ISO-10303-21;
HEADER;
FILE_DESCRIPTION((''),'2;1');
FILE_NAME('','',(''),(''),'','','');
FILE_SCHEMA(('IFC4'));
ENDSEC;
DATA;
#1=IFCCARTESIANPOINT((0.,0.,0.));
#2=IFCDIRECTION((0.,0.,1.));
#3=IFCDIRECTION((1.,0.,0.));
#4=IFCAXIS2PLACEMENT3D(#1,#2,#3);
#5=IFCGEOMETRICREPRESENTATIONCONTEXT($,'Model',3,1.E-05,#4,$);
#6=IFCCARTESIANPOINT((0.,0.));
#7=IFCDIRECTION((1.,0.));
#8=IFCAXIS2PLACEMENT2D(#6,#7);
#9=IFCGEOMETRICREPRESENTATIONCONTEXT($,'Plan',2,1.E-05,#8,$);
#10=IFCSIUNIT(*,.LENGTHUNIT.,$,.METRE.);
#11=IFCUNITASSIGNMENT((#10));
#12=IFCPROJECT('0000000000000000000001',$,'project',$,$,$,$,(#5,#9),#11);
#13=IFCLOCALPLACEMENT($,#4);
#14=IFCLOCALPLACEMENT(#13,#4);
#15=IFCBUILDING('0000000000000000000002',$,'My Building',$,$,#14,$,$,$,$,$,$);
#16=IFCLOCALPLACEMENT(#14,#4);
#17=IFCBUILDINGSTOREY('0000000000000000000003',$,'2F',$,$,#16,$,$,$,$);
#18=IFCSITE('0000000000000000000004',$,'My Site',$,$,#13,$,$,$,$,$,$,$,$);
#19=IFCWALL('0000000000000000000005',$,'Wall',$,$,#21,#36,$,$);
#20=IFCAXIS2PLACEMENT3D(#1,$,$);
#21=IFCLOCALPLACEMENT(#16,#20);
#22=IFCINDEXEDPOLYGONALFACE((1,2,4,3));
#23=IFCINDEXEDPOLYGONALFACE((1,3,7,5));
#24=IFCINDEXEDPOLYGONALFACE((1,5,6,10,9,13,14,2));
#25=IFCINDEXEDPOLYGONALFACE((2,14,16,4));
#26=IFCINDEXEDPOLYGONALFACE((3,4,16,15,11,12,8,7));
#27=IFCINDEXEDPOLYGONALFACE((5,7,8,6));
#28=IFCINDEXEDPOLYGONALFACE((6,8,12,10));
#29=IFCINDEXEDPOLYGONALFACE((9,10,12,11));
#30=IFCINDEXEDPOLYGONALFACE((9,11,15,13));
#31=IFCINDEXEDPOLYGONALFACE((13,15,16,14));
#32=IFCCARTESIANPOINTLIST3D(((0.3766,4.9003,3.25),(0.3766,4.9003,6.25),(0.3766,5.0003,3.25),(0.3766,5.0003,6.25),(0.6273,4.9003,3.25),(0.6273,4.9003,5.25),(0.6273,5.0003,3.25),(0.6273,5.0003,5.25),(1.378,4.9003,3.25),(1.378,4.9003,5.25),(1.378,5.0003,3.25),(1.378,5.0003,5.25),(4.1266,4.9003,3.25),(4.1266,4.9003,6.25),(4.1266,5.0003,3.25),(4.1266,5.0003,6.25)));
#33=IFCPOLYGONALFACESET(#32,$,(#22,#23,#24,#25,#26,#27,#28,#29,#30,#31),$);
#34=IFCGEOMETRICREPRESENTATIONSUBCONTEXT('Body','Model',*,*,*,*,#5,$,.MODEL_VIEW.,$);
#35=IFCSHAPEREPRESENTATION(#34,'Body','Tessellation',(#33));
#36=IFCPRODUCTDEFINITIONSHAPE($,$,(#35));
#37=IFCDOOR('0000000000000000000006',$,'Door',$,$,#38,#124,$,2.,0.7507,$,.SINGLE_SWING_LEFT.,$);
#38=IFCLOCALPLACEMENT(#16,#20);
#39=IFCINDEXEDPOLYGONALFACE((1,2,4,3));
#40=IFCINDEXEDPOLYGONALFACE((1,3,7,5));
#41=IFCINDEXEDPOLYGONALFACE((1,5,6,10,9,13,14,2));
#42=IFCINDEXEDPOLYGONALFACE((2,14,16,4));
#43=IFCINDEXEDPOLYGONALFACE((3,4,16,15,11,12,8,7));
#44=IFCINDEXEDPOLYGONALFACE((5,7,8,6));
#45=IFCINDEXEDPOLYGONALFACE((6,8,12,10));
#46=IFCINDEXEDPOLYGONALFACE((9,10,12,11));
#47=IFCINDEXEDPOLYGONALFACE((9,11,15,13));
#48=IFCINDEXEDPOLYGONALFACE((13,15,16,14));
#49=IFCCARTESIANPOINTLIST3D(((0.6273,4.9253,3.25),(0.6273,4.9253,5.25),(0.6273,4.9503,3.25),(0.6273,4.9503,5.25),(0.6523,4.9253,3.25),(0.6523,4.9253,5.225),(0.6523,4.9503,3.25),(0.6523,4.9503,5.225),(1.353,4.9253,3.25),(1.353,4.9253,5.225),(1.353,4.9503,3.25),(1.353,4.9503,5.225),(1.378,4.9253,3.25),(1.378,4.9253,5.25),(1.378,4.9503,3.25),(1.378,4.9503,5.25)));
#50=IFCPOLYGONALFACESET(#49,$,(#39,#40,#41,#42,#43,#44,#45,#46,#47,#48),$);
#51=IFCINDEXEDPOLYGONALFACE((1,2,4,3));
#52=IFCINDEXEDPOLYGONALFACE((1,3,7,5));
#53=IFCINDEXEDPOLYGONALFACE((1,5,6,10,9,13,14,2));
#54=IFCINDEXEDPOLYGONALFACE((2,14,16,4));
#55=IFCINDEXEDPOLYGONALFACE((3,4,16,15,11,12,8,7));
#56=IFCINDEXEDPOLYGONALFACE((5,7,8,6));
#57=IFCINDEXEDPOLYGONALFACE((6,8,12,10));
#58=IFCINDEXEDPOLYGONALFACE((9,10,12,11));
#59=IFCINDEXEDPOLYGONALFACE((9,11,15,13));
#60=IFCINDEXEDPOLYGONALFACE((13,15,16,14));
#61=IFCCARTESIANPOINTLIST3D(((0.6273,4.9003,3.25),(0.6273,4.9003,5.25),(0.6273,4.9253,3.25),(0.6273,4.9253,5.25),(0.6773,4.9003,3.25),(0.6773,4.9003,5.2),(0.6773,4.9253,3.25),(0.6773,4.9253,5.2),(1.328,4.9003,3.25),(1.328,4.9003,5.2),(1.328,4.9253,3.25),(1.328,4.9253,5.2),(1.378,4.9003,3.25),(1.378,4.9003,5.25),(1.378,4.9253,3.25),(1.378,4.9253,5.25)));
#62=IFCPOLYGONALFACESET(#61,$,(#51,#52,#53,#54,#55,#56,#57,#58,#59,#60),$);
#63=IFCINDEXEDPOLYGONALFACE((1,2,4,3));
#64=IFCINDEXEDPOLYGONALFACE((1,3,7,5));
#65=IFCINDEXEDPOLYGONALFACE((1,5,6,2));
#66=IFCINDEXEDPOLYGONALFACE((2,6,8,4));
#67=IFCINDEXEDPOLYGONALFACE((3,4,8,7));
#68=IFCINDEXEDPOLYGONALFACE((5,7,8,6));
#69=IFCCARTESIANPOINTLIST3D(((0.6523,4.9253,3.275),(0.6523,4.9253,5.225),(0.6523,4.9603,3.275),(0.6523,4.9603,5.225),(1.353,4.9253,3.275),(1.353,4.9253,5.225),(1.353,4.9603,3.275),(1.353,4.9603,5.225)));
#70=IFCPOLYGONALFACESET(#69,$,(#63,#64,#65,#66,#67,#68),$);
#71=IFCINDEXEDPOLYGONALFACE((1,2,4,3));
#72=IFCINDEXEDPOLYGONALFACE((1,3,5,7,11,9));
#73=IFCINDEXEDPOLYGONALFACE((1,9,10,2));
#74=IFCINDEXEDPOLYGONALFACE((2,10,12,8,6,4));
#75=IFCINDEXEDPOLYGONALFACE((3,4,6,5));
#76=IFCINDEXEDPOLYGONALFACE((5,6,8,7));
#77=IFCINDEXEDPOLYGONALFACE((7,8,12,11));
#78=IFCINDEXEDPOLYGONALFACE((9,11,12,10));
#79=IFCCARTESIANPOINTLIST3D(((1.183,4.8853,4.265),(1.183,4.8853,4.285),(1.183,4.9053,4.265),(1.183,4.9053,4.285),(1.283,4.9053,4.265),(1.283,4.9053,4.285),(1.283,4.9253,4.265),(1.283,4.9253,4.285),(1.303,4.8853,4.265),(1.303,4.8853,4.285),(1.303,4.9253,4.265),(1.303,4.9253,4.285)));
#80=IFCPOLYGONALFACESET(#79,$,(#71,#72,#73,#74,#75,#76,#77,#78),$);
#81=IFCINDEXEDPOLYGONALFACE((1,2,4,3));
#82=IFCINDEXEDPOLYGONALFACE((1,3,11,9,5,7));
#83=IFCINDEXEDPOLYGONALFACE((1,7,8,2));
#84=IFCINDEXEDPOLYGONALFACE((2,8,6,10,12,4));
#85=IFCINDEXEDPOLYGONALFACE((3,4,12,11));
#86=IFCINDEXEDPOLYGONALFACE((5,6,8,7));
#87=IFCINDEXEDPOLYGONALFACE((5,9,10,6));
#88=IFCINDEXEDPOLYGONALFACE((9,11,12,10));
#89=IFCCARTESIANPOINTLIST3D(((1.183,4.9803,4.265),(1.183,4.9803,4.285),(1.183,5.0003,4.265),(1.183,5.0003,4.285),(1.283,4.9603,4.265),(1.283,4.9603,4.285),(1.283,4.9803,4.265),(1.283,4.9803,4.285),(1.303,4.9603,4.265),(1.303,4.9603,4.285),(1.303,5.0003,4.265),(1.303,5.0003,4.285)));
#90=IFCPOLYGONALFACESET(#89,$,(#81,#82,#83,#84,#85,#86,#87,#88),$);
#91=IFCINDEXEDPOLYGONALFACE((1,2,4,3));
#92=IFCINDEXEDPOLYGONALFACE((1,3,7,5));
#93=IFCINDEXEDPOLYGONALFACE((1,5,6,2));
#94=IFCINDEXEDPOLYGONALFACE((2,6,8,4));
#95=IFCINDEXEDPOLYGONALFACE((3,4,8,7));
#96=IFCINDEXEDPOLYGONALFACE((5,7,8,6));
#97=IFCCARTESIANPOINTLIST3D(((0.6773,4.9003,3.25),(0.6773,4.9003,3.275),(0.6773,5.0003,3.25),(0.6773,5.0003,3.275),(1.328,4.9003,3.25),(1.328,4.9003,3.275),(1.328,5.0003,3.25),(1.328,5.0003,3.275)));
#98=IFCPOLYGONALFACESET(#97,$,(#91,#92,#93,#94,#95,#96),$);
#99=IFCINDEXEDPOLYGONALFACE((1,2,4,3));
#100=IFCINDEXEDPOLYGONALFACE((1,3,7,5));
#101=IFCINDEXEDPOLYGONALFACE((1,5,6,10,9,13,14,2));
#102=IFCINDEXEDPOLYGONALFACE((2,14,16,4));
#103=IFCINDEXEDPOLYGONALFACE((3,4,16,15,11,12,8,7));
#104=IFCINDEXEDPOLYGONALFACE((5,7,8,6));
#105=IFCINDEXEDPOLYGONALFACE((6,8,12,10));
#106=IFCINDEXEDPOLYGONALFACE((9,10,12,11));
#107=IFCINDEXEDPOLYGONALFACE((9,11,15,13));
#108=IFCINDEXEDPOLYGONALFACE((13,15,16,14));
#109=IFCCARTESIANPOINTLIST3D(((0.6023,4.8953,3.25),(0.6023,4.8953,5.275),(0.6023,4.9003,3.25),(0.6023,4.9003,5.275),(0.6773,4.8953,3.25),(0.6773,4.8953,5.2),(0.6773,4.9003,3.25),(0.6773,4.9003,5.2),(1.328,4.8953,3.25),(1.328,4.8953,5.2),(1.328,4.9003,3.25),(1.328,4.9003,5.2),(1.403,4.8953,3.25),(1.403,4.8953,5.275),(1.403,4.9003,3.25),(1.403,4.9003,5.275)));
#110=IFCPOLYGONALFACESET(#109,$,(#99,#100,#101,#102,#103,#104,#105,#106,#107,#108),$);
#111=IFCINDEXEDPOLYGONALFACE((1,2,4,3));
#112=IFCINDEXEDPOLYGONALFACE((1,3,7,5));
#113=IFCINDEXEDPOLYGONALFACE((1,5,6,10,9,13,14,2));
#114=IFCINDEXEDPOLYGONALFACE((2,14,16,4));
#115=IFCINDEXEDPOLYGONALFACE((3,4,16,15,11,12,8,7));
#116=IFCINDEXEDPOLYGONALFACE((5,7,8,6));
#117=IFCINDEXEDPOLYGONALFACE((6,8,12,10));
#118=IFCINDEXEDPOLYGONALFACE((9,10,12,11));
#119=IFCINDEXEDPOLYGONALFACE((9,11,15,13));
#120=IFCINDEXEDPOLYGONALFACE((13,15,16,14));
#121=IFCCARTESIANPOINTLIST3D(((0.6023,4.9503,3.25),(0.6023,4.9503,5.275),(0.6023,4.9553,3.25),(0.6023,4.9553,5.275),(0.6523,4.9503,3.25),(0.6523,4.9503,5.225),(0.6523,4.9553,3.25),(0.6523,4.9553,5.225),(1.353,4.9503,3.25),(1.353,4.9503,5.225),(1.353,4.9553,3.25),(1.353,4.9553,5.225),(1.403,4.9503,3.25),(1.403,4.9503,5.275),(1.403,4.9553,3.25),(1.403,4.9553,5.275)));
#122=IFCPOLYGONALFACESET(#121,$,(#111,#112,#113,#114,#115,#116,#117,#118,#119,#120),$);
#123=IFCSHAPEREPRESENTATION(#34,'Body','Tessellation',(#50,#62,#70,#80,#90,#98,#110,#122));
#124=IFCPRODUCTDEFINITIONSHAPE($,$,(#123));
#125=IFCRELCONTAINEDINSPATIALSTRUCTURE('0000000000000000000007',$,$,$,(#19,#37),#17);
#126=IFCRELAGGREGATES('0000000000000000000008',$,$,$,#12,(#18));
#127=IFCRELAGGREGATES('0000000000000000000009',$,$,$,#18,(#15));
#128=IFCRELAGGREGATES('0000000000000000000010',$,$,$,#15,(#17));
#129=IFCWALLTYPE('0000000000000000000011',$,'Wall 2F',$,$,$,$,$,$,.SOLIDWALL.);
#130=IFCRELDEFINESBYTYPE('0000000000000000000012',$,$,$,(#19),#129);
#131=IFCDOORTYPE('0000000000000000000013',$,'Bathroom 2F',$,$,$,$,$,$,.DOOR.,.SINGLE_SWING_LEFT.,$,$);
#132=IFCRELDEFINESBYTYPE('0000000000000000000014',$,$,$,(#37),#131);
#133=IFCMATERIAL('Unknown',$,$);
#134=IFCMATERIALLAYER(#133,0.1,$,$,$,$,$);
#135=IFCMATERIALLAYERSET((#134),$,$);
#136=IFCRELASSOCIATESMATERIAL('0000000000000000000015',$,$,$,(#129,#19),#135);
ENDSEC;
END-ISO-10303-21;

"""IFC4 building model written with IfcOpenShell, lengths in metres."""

from ifc_helpers import new_model, entity, si_unit, frame, origin_with_axes, origin_2d_with_axis, place, context, subcontext, project, spatial, line, indexed_curve, outline, extrude, shape, source, transform, mapped, material, layer, layer_set, layer_usage, type_object, type_shapes, element, fill, save


model = new_model("IFC4")

# Units and contexts
model_context = context("Model", 3, precision=1e-05, world=origin_with_axes())
plan_context = context("Plan", 2, precision=1e-05, world=origin_2d_with_axis())
body_context_1 = subcontext(model_context, "Body", "Model", "MODEL_VIEW")
body_context_2 = subcontext(plan_context, "Body", "Plan", "PLAN_VIEW")
ifc_project = project(units=[si_unit("LENGTHUNIT", "METRE")], contexts=[model_context, plan_context])

# Site, building, storey
site_placement = place(None, origin_with_axes())
site = spatial("IfcSite", under=ifc_project, at=site_placement, Name="My Site")
building_placement = place(site_placement, origin_with_axes())
building = spatial("IfcBuilding", under=site, at=building_placement, Name="My Building")
storey_placement = place(building_placement, origin_with_axes())
storey = spatial("IfcBuildingStorey", under=building, at=storey_placement, Name="2F")

# Shared definitions
ifc_material = material(Name="Unknown")

# Shared definitions
ifc_layer = layer(ifc_material, 0.1)
ifc_layer_set = layer_set([ifc_layer])
wall_type = type_object("IfcWallType", Name="Wall 2F", PredefinedType="SOLIDWALL", material=ifc_layer_set)

# Wall, opening, door
ifc_layer_usage_1 = layer_usage(ifc_layer_set, "AXIS2", "POSITIVE", 0.0)
wall_1_placement = place(storey_placement, frame((4.2266, 5.0003, 3.25), z_axis=(0.0, 0.0, 1.0), x_axis=(-1.0, 0.0, 0.0)))
wall_1 = element("IfcWall", 1, at=wall_1_placement, inside=storey, type_object=wall_type, material=ifc_layer_usage_1, Name="Wall", context=body_context_1, shape_type="SweptSolid", body=[
    extrude(outline(indexed_curve([(0.1, 0.0), (0.1, 0.1), (3.85, 0.1), (3.85, 0.0)], segments=[line(1, 2, 3, 4, 1)])), origin_with_axes(), (0.0, 0.0, 1.0), 3.0),
])
shared_shape_1 = source(origin_with_axes(), body_context_1, "Body", "SweptSolid", [
    extrude(outline(indexed_curve([(0.0, 0.0), (0.7507, 0.0), (0.7507, 2.0), (0.0, 2.0)], segments=[line(1, 2, 3, 4, 1)])), frame((0.0, -0.6, 0.0), z_axis=(0.0, -1.0, 0.0), x_axis=(1.0, 0.0, 0.0)), (0.0, 0.0, -1.0), 1.2),
])
opening_1_placement = place(wall_1_placement, frame((3.5993, 0.1, 0.0), z_axis=(0.0, 0.0, 1.0), x_axis=(-1.0, 0.000001, 0.0)))
opening_1 = element("IfcOpeningElement", 2, at=opening_1_placement, cuts=wall_1, PredefinedType="OPENING", context=body_context_1, shape_type="MappedRepresentation", body=[
    mapped(shared_shape_1, transform((0.0, 0.0, 0.0), x_axis=(1.0, 0.0, 0.0), y_axis=(0.0, 1.0, 0.0), z_axis=(0.0, 0.0, 1.0), scale=1.0)),
])
door_type_1 = type_object("IfcDoorType", Name="Bathroom 2F", OperationType="SINGLE_SWING_LEFT", PredefinedType="DOOR")
shared_shape_2 = source(origin_with_axes(), body_context_1, "Body", "SweptSolid", [
    extrude(outline(indexed_curve([(0.0, 0.0), (0.0, 2.0), (0.7507, 2.0), (0.7507, 0.0), (0.7257, 0.0), (0.7257, 1.975), (0.025, 1.975), (0.025, 0.0)], segments=[line(1, 2, 3, 4, 5, 6, 7, 8, 1)])), frame((0.0, 0.025, 0.0), z_axis=(0.0, -1.0, 0.0), x_axis=(1.0, 0.0, 0.0)), (0.0, 0.0, -1.0), 0.025),
    extrude(outline(indexed_curve([(0.0, 0.0), (0.0, 2.0), (0.7507, 2.0), (0.7507, 0.0), (0.7007, 0.0), (0.7007, 1.95), (0.05, 1.95), (0.05, 0.0)], segments=[line(1, 2, 3, 4, 5, 6, 7, 8, 1)])), frame((0.0, 0.0, 0.0), z_axis=(0.0, -1.0, 0.0), x_axis=(1.0, 0.0, 0.0)), (0.0, 0.0, -1.0), 0.025),
    extrude(outline(indexed_curve([(0.0, 0.0), (0.7007, 0.0), (0.7007, 0.035), (0.0, 0.035)], segments=[line(1, 2, 3, 4, 1)])), frame((0.025, 0.025, 0.025), z_axis=(0.0, 0.0, 1.0), x_axis=(1.0, 0.0, 0.0)), (0.0, 0.0, 1.0), 1.95),
    extrude(outline(indexed_curve([(0.0, 0.0), (0.0, -0.04), (-0.12, -0.04), (-0.12, -0.02), (-0.02, -0.02), (-0.02, 0.0)], segments=[line(1, 2, 3, 4, 5, 6, 1)])), frame((0.6757, 0.025, 1.015), z_axis=(0.0, 0.0, 1.0), x_axis=(1.0, 0.0, 0.0)), (0.0, 0.0, 1.0), 0.02),
    extrude(outline(indexed_curve([(0.0, 0.0), (0.0, 0.04), (-0.12, 0.04), (-0.12, 0.02), (-0.02, 0.02), (-0.02, 0.0)], segments=[line(1, 2, 3, 4, 5, 6, 1)])), frame((0.6757, 0.06, 1.015), z_axis=(0.0, 0.0, 1.0), x_axis=(1.0, 0.0, 0.0)), (0.0, 0.0, 1.0), 0.02),
    extrude(outline(indexed_curve([(0.0, 0.0), (0.6507, 0.0), (0.6507, 0.1), (0.0, 0.1)], segments=[line(1, 2, 3, 4, 1)])), frame((0.05, 0.0, 0.0), z_axis=(0.0, 0.0, 1.0), x_axis=(1.0, 0.0, 0.0)), (0.0, 0.0, 1.0), 0.025),
    extrude(outline(indexed_curve([(0.0, 0.0), (0.0, 2.025), (0.8007, 2.025), (0.8007, 0.0), (0.7257, 0.0), (0.7257, 1.95), (0.075, 1.95), (0.075, 0.0)], segments=[line(1, 2, 3, 4, 5, 6, 7, 8, 1)])), frame((-0.025, -0.005, 0.0), z_axis=(0.0, -1.0, 0.0), x_axis=(1.0, 0.0, 0.0)), (0.0, 0.0, -1.0), 0.005),
    extrude(outline(indexed_curve([(0.0, 0.0), (0.0, 2.025), (0.8007, 2.025), (0.8007, 0.0), (0.7507, 0.0), (0.7507, 1.975), (0.05, 1.975), (0.05, 0.0)], segments=[line(1, 2, 3, 4, 5, 6, 7, 8, 1)])), frame((-0.025, 0.05, 0.0), z_axis=(0.0, -1.0, 0.0), x_axis=(1.0, 0.0, 0.0)), (0.0, 0.0, -1.0), 0.005),
])
shared_shape_3 = source(origin_with_axes(), body_context_2, "Body", "Curve2D", [
    entity("IfcIndexedPolyCurve", entity("IfcCartesianPointList2D", [[0.0, 0.0], [0.0, 0.05], [0.025, 0.05], [0.025, 0.025], [0.05, 0.025], [0.05, 0.0]]), [entity("IfcLineIndex", [1, 2, 3, 4, 5, 6, 1])]),
    entity("IfcIndexedPolyCurve", entity("IfcCartesianPointList2D", [[0.7507, 0.0], [0.7507, 0.05], [0.7257, 0.05], [0.7257, 0.025], [0.7007, 0.025], [0.7007, 0.0]]), [entity("IfcLineIndex", [1, 2, 3, 4, 5, 6, 1])]),
    entity("IfcTrimmedCurve", entity("IfcEllipse", entity("IfcAxis2Placement2D", entity("IfcCartesianPoint", [0.06, 0.05]), entity("IfcDirection", [1.0, 0.0])), 0.6657, 0.7007), [entity("IfcCartesianPoint", [0.7257, 0.05])], [entity("IfcCartesianPoint", [0.06, 0.7507])], True, "CARTESIAN"),
    entity("IfcIndexedPolyCurve", entity("IfcCartesianPointList2D", [[0.025, 0.05], [0.06, 0.05], [0.06, 0.7507], [0.025, 0.7507]]), [entity("IfcLineIndex", [1, 2, 3, 4, 1])]),
])
type_shapes(door_type_1, [shared_shape_2, shared_shape_3])
door_1_placement = place(opening_1_placement, frame((0.0, 0.0, 0.0), z_axis=(0.0, 0.0, 1.0), x_axis=(1.0, 0.0, 0.0)))
door_1 = element("IfcDoor", 3, at=door_1_placement, inside=storey, type_object=door_type_1, Name="Door", OperationType="SINGLE_SWING_LEFT", OverallHeight=2.0, OverallWidth=0.7507, shapes=[
    shape(body_context_1, "Body", "MappedRepresentation", [mapped(shared_shape_2, transform((0.0, 0.0, 0.0), x_axis=(1.0, 0.0, 0.0), y_axis=(0.0, 1.0, 0.0), z_axis=(0.0, 0.0, 1.0), scale=1.0))]),
    shape(body_context_2, "Body", "MappedRepresentation", [mapped(shared_shape_3, transform((0.0, 0.0, 0.0), x_axis=(1.0, 0.0, 0.0), y_axis=(0.0, 1.0, 0.0), z_axis=(0.0, 0.0, 1.0), scale=1.0))]),
])
fill(opening_1, door_1)

save(model, "model.ifc")
